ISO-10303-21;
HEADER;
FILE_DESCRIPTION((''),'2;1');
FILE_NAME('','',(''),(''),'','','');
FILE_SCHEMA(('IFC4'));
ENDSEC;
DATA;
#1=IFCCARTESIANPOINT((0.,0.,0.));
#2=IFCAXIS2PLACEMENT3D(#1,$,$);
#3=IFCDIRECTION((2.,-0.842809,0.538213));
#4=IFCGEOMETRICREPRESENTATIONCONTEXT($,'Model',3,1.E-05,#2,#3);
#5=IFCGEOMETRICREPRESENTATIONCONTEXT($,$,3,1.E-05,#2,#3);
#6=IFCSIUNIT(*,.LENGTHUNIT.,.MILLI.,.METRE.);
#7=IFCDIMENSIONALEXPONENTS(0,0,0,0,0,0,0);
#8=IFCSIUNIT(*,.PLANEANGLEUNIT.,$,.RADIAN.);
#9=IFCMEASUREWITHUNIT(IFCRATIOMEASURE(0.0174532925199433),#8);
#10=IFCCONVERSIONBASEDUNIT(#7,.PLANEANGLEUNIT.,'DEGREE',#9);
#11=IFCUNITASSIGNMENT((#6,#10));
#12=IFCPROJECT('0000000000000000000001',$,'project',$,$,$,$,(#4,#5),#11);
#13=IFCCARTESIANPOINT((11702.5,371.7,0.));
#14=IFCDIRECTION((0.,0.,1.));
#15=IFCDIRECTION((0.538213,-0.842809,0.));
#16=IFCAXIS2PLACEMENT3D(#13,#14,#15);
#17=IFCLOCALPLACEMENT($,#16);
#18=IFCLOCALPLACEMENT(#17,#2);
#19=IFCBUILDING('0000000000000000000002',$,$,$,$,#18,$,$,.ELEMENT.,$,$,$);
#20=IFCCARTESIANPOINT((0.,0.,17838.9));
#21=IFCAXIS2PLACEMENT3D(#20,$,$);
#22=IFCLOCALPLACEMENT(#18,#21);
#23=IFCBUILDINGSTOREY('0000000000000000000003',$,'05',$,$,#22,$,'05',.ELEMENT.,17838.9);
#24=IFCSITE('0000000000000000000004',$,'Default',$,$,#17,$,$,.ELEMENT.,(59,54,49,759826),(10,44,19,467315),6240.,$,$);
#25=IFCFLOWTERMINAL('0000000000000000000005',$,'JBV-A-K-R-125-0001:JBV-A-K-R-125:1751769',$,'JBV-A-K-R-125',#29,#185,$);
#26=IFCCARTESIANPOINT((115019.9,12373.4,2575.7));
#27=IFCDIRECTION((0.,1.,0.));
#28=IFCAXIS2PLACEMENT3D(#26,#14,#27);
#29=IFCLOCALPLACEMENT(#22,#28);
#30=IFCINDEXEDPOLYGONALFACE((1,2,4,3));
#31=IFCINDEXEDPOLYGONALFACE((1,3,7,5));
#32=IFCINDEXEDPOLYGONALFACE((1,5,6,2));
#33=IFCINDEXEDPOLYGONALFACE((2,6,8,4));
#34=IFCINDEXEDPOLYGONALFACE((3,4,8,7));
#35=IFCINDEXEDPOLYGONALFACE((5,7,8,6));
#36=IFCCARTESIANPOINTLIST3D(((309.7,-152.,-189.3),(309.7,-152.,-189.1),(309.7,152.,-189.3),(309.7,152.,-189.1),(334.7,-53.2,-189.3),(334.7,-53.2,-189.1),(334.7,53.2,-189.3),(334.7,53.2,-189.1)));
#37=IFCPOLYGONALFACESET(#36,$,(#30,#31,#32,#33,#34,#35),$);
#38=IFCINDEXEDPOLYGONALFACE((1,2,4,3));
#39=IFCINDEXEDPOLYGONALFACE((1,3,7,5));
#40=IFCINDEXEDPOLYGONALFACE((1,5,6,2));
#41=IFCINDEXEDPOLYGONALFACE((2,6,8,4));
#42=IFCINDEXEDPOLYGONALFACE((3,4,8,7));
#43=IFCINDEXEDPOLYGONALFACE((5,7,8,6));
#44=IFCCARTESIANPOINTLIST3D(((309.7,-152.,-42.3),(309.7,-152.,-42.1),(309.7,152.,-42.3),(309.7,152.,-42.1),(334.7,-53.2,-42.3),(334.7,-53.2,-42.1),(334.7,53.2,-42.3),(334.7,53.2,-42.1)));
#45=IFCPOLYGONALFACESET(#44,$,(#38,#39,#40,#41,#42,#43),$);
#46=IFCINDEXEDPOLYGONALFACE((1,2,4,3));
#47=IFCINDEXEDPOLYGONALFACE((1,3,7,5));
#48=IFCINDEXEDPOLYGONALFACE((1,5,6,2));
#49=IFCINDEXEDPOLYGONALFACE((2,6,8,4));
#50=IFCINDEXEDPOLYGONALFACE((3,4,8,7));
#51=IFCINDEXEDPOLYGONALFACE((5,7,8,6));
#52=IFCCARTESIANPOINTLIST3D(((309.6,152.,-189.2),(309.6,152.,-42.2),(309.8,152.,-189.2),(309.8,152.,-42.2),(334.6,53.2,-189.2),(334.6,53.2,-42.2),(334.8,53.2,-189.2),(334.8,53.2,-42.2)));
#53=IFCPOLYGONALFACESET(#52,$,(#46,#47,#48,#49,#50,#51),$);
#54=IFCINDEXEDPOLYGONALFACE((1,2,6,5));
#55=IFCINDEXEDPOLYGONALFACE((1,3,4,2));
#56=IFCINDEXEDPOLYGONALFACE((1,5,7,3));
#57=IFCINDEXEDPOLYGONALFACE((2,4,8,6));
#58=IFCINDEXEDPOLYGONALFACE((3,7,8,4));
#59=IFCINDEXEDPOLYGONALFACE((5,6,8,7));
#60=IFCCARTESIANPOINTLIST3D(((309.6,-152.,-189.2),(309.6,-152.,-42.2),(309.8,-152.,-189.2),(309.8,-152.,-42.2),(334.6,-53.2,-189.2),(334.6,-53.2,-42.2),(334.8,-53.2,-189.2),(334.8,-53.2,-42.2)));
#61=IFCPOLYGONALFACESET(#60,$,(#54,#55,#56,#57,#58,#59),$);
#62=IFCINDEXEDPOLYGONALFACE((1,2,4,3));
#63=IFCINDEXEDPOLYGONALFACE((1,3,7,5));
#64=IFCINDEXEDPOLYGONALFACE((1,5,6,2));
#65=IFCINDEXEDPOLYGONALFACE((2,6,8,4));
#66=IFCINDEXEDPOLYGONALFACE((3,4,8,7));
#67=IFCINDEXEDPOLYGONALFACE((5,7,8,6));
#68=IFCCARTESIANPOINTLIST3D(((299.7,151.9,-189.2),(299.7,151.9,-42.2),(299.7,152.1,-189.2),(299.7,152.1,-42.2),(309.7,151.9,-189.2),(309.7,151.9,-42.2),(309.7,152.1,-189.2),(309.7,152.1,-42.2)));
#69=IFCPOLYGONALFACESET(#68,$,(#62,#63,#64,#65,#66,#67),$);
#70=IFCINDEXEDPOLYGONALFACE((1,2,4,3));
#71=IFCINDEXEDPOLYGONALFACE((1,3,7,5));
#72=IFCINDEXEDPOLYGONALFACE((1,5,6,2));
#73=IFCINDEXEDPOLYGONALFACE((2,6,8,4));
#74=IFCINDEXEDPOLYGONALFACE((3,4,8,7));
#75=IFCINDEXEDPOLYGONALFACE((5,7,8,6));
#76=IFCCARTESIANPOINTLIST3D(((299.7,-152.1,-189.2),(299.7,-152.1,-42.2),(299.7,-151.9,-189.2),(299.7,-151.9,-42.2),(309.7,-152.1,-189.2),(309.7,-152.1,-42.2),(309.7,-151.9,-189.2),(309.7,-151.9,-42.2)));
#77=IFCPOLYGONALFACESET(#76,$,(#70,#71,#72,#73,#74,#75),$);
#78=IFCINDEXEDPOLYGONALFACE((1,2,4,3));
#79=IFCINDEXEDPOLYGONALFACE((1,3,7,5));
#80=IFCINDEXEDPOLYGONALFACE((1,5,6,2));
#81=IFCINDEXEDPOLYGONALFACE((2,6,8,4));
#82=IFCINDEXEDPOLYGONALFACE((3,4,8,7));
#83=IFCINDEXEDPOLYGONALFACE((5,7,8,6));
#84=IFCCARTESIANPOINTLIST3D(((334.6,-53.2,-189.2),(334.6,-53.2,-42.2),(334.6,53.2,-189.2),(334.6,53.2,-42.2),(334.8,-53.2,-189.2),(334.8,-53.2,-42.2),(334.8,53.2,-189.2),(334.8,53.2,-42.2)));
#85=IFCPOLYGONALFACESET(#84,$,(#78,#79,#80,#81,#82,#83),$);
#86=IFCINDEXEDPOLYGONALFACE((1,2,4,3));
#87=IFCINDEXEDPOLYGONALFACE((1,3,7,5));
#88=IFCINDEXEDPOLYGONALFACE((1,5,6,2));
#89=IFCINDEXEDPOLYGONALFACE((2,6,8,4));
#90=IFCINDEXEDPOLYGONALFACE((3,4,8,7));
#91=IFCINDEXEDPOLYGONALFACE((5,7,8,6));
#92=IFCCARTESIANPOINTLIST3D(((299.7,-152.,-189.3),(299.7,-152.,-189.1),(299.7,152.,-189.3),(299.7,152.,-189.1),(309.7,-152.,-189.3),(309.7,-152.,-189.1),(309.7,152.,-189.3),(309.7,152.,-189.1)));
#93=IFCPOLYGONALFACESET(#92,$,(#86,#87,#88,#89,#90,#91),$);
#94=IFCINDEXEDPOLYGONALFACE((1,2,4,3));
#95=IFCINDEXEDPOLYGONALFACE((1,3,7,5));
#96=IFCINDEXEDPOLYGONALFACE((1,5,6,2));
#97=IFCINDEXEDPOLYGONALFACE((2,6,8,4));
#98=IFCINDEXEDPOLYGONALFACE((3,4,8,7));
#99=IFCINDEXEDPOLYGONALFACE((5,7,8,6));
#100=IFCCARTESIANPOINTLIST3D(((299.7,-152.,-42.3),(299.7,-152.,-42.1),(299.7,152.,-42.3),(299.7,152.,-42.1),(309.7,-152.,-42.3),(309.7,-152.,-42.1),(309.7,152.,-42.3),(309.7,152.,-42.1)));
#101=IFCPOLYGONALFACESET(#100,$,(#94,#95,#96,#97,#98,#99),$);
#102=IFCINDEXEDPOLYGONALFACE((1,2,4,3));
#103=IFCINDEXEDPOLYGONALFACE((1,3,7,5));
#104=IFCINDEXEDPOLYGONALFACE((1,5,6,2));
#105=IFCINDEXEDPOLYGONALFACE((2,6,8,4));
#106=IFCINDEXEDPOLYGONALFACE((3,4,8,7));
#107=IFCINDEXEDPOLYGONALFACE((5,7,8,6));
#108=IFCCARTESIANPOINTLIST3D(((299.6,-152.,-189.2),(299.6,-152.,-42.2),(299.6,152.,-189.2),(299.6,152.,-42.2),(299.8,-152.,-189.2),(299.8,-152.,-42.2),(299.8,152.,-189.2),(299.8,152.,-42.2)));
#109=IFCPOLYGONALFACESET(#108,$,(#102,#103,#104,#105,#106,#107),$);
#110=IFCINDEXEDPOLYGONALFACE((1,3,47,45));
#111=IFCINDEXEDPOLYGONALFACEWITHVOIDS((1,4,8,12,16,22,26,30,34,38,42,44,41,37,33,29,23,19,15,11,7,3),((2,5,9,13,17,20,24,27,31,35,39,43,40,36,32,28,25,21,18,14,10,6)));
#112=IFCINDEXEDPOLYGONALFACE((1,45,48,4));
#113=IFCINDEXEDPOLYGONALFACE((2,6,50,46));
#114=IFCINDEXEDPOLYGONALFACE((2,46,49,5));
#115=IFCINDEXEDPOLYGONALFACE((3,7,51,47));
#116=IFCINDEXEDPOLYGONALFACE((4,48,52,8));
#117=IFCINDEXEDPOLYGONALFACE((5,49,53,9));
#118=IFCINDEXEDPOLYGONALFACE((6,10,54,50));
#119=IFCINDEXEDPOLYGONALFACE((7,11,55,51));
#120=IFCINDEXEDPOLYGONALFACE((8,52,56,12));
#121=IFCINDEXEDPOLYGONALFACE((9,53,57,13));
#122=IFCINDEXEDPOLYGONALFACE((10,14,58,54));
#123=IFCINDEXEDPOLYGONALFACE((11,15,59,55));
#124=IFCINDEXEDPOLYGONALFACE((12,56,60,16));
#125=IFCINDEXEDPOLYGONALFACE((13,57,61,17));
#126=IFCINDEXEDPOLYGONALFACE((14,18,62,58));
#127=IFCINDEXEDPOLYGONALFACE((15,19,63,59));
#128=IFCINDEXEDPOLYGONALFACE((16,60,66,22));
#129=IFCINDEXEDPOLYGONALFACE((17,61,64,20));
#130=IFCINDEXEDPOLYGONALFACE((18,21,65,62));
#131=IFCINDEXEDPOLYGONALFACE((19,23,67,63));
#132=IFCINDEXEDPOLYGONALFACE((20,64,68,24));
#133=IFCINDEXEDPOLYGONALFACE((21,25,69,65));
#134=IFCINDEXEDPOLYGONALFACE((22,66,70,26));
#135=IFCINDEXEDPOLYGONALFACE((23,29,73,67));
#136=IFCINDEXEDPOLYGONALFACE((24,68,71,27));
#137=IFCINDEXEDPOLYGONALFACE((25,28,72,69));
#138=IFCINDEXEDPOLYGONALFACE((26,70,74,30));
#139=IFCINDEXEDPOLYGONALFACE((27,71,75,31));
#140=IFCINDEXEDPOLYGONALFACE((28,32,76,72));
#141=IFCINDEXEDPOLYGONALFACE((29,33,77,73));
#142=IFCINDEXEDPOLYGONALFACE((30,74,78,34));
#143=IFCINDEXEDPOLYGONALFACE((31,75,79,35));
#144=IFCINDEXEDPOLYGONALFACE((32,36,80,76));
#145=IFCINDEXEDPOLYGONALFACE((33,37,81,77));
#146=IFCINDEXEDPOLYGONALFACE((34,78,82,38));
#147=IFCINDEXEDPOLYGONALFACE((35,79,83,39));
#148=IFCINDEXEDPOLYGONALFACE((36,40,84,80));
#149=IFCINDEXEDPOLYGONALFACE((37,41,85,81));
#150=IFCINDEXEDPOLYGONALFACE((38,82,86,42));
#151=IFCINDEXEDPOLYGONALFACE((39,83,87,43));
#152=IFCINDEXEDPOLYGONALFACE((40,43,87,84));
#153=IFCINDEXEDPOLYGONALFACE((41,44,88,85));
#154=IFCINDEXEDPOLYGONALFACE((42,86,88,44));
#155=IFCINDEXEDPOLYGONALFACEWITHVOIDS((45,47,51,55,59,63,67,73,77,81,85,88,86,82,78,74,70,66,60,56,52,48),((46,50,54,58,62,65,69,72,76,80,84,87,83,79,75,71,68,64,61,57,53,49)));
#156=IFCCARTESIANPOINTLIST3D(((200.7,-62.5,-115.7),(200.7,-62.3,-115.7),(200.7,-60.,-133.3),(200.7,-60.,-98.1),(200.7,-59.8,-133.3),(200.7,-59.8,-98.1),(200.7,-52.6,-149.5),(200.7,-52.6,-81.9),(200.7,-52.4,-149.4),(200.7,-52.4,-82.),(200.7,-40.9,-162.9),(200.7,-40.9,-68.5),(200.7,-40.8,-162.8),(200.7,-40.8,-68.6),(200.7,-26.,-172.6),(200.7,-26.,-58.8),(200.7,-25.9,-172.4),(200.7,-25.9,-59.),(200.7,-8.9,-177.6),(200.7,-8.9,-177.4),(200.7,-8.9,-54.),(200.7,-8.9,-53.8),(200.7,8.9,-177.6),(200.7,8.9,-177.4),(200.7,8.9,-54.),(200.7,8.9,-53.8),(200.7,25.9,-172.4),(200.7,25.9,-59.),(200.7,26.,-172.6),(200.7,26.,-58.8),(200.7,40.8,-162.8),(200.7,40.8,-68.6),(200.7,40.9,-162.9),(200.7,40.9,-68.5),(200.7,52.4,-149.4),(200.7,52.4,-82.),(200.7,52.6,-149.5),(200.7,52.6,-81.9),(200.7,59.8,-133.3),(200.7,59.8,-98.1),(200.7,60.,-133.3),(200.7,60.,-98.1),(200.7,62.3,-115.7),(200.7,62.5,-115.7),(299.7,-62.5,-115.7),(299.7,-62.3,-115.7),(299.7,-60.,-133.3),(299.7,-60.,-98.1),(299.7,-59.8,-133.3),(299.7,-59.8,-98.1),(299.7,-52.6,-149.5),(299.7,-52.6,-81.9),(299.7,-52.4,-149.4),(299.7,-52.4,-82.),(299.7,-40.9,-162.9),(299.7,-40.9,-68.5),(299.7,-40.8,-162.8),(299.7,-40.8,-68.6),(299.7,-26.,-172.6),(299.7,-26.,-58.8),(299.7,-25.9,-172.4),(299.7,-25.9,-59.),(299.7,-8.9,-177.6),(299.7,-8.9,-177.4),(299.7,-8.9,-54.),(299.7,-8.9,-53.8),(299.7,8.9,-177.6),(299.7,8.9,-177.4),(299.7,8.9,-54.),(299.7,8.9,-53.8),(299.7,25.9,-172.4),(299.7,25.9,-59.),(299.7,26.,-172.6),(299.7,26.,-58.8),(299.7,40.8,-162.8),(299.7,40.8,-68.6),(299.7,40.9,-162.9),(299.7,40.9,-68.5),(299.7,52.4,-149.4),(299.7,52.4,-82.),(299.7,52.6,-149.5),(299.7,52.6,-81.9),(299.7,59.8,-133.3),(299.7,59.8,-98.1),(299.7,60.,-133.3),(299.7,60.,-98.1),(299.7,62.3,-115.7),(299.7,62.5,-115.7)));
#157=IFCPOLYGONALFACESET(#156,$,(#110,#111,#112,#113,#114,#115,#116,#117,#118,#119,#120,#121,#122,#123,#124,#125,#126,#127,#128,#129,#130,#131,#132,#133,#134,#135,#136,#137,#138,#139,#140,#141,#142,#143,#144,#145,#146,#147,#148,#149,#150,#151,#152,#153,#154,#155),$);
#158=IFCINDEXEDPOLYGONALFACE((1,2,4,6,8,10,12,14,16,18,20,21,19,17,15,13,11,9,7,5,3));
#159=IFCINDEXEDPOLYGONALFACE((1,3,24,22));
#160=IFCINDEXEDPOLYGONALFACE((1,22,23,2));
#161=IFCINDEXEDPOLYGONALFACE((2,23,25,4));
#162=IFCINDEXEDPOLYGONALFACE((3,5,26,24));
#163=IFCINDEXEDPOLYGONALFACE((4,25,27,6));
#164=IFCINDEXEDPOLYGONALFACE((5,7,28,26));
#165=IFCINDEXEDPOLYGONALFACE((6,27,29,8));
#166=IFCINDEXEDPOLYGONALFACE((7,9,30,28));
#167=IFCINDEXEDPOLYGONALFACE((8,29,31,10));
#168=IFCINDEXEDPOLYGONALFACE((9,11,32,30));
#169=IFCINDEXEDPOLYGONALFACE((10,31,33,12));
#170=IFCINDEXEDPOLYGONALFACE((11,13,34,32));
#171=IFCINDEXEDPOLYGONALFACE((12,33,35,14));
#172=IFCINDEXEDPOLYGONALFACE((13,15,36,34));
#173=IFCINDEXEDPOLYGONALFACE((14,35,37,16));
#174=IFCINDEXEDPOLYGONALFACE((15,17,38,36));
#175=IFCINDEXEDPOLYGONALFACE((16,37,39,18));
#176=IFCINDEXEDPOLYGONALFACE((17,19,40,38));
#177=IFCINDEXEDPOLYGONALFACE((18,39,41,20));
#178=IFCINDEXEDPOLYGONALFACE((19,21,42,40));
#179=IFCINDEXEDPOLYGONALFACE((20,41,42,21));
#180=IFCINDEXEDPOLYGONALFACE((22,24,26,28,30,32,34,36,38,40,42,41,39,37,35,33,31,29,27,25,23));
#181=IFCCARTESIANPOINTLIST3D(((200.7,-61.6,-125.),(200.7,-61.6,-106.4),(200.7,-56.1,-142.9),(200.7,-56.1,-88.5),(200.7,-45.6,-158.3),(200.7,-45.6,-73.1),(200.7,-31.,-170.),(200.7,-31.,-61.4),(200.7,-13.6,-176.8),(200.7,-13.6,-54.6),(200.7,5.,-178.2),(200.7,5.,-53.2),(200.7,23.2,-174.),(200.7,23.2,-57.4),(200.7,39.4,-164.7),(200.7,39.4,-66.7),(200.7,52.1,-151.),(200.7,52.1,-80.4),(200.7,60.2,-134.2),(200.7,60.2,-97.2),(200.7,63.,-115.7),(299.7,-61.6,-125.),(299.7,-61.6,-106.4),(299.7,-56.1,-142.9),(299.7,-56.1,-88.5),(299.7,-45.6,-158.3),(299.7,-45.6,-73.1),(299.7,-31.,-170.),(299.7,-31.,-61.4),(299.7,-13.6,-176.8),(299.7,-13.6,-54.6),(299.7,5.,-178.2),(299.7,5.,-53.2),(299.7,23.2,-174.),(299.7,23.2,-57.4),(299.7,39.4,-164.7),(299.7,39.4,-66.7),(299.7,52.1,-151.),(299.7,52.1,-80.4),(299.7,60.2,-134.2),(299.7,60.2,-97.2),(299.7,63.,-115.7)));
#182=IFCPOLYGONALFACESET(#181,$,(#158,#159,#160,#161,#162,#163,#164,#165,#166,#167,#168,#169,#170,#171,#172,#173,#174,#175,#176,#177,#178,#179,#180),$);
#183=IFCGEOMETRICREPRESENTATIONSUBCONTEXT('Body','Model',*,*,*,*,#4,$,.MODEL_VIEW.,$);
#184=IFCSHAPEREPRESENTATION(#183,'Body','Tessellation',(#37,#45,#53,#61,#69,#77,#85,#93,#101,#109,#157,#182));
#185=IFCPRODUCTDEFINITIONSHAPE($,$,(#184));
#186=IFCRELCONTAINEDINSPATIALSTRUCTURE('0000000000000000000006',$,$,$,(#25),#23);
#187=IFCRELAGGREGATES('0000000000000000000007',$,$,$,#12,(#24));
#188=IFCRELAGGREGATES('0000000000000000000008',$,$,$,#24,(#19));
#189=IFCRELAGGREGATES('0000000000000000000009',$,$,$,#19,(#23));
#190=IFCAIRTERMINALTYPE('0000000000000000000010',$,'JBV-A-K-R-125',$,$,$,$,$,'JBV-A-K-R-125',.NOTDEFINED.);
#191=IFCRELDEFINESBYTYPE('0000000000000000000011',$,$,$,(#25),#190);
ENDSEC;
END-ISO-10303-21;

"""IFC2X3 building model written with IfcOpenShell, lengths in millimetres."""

from ifc_helpers import new_model, entity, si_unit, converted_unit, direction, frame, frame_2d, origin, origin_2d_with_axis, place, context, subcontext, project, spatial, polyline, circle_curve, parameter, trimmed, segment, composite_curve, rectangle, circle, outline, extrude, source, transform, mapped, type_object, type_shapes, element, save


model = new_model("IFC2X3")

# Units and contexts
model_context = context("Model", 3, precision=1e-05, world=origin(), true_north=direction((2.0, -0.842809, 0.538213)))
context_of_model = context(None, 3, precision=1e-05, world=origin(), true_north=direction((2.0, -0.842809, 0.538213)))
body_context = subcontext(model_context, "Body", "Model", "MODEL_VIEW")
ifc_project = project(units=[si_unit("LENGTHUNIT", "METRE", prefix="MILLI"), converted_unit("PLANEANGLEUNIT", "DEGREE", entity("IfcRatioMeasure", 0.0174532925199433), si_unit("PLANEANGLEUNIT", "RADIAN"), dimensions=[0, 0, 0, 0, 0, 0, 0])], contexts=[model_context, context_of_model])

# Site, building, storey
site_placement = place(None, frame((11702.5, 371.7, 0.0), z_axis=(0.0, 0.0, 1.0), x_axis=(0.538213, -0.842809, 0.0)))
site = spatial("IfcSite", under=ifc_project, at=site_placement, Name="Default", CompositionType="ELEMENT", RefLatitude=(59, 54, 49, 759826), RefLongitude=(10, 44, 19, 467315), RefElevation=6240.0)
building_placement = place(site_placement, origin())
building = spatial("IfcBuilding", under=site, at=building_placement, CompositionType="ELEMENT")
storey_placement = place(building_placement, frame((0.0, 0.0, 17838.9)))
storey = spatial("IfcBuildingStorey", under=building, at=storey_placement, Name="05", LongName="05", CompositionType="ELEMENT", Elevation=17838.9)

# Flow terminal
air_terminal_type_1 = type_object("IfcAirTerminalType", Name="JBV-A-K-R-125", ElementType="JBV-A-K-R-125", PredefinedType="NOTDEFINED")
shared_shape_1 = source(origin(), body_context, "Body", "SweptSolid", [
    extrude(outline(polyline([(-152.0, -12.5), (152.0, -12.5), (53.2, 12.5), (-53.2, 12.5), (-152.0, -12.5)])), frame((322.2, 0.0, -189.3), z_axis=(0.0, 0.0, 1.0), x_axis=(0.0, -1.0, 0.0)), (0.0, 0.0, 1.0), 0.2),
    extrude(outline(polyline([(-152.0, -12.5), (152.0, -12.5), (53.2, 12.5), (-53.2, 12.5), (-152.0, -12.5)])), frame((322.2, 0.0, -42.3), z_axis=(0.0, 0.0, 1.0), x_axis=(0.0, -1.0, 0.0)), (0.0, 0.0, 1.0), 0.2),
    extrude(rectangle(XDim=0.2, YDim=101.9, at=frame_2d((0.0, 0.0), x_axis=(1.0, 0.0))), frame((322.2, 102.6, -189.2), z_axis=(0.0, 0.0, 1.0), x_axis=(0.969446, 0.245305, 0.0)), (0.0, 0.0, 1.0), 147.0),
    extrude(rectangle(XDim=0.2, YDim=101.9, at=frame_2d((0.0, 0.0), x_axis=(1.0, 0.0))), frame((322.2, -102.6, -189.2), z_axis=(0.0, 0.0, 1.0), x_axis=(-0.969446, 0.245305, 0.0)), (0.0, 0.0, 1.0), 147.0),
    extrude(rectangle(XDim=0.2, YDim=10.0, at=frame_2d((0.0, 0.0), x_axis=(1.0, 0.0))), frame((304.7, 152.0, -189.2), z_axis=(0.0, 0.0, 1.0), x_axis=(0.0, 1.0, 0.0)), (0.0, 0.0, 1.0), 147.0),
    extrude(rectangle(XDim=0.2, YDim=10.0, at=frame_2d((0.0, 0.0), x_axis=(1.0, 0.0))), frame((304.7, -152.0, -189.2), z_axis=(0.0, 0.0, 1.0), x_axis=(0.0, 1.0, 0.0)), (0.0, 0.0, 1.0), 147.0),
    extrude(rectangle(XDim=0.2, YDim=106.4, at=frame_2d((0.0, 0.0), x_axis=(1.0, 0.0))), frame((334.7, 0.0, -189.2)), (0.0, 0.0, 1.0), 147.0),
    extrude(rectangle(XDim=304.0, YDim=10.0, at=frame_2d((0.0, 0.0), x_axis=(1.0, 0.0))), frame((304.7, 0.0, -189.3), z_axis=(0.0, 0.0, 1.0), x_axis=(0.0, -1.0, 0.0)), (0.0, 0.0, 1.0), 0.2),
    extrude(rectangle(XDim=304.0, YDim=10.0, at=frame_2d((0.0, 0.0), x_axis=(1.0, 0.0))), frame((304.7, 0.0, -42.3), z_axis=(0.0, 0.0, 1.0), x_axis=(0.0, -1.0, 0.0)), (0.0, 0.0, 1.0), 0.2),
    extrude(rectangle(XDim=0.2, YDim=304.0, at=frame_2d((0.0, 0.0), x_axis=(1.0, 0.0))), frame((299.7, 0.0, -189.2)), (0.0, 0.0, 1.0), 147.0),
    extrude(outline(composite_curve([segment(trimmed(circle_curve(origin_2d_with_axis(), 62.5), [parameter(0.0)], [parameter(180.0)], True, "PARAMETER"), True, "CONTINUOUS"), segment(trimmed(circle_curve(origin_2d_with_axis(), 62.5), [parameter(180.0)], [parameter(360.0)], True, "PARAMETER"), True, "CONTINUOUS")], self_intersect=False), holes=[composite_curve([segment(trimmed(circle_curve(origin_2d_with_axis(), 62.3), [parameter(180.0)], [parameter(360.0)], True, "PARAMETER"), False, "CONTINUOUS"), segment(trimmed(circle_curve(origin_2d_with_axis(), 62.3), [parameter(0.0)], [parameter(180.0)], True, "PARAMETER"), False, "CONTINUOUS")], self_intersect=False)]), frame((200.7, 0.0, -115.7), z_axis=(1.0, 0.0, 0.0), x_axis=(0.0, 1.0, 0.0)), (0.0, 0.0, 1.0), 99.0),
    extrude(circle(Radius=62.6, at=frame_2d((0.0, 0.0), x_axis=(1.0, 0.0))), frame((200.7, 0.3, -115.7), z_axis=(1.0, 0.0, 0.0), x_axis=(0.0, 1.0, 0.0)), (0.0, 0.0, 1.0), 99.0),
])
type_shapes(air_terminal_type_1, [shared_shape_1])
for number, where, z_axis, x_axis, name in (
    (1, (115019.9, 12373.4, 2575.7), (0.0, 0.0, 1.0), (0.0, 1.0, 0.0), "JBV-A-K-R-125-0001:JBV-A-K-R-125:1751769"),
):
    element("IfcFlowTerminal", number, at=place(storey_placement, frame(where, z_axis=z_axis, x_axis=x_axis)), inside=storey, type_object=air_terminal_type_1, Name=name, ObjectType="JBV-A-K-R-125", context=body_context, shape_type="MappedRepresentation", body=[
        mapped(shared_shape_1, transform((0.0, 0.0, 0.0), scale=1.0)),
    ])

save(model, "model.ifc")
